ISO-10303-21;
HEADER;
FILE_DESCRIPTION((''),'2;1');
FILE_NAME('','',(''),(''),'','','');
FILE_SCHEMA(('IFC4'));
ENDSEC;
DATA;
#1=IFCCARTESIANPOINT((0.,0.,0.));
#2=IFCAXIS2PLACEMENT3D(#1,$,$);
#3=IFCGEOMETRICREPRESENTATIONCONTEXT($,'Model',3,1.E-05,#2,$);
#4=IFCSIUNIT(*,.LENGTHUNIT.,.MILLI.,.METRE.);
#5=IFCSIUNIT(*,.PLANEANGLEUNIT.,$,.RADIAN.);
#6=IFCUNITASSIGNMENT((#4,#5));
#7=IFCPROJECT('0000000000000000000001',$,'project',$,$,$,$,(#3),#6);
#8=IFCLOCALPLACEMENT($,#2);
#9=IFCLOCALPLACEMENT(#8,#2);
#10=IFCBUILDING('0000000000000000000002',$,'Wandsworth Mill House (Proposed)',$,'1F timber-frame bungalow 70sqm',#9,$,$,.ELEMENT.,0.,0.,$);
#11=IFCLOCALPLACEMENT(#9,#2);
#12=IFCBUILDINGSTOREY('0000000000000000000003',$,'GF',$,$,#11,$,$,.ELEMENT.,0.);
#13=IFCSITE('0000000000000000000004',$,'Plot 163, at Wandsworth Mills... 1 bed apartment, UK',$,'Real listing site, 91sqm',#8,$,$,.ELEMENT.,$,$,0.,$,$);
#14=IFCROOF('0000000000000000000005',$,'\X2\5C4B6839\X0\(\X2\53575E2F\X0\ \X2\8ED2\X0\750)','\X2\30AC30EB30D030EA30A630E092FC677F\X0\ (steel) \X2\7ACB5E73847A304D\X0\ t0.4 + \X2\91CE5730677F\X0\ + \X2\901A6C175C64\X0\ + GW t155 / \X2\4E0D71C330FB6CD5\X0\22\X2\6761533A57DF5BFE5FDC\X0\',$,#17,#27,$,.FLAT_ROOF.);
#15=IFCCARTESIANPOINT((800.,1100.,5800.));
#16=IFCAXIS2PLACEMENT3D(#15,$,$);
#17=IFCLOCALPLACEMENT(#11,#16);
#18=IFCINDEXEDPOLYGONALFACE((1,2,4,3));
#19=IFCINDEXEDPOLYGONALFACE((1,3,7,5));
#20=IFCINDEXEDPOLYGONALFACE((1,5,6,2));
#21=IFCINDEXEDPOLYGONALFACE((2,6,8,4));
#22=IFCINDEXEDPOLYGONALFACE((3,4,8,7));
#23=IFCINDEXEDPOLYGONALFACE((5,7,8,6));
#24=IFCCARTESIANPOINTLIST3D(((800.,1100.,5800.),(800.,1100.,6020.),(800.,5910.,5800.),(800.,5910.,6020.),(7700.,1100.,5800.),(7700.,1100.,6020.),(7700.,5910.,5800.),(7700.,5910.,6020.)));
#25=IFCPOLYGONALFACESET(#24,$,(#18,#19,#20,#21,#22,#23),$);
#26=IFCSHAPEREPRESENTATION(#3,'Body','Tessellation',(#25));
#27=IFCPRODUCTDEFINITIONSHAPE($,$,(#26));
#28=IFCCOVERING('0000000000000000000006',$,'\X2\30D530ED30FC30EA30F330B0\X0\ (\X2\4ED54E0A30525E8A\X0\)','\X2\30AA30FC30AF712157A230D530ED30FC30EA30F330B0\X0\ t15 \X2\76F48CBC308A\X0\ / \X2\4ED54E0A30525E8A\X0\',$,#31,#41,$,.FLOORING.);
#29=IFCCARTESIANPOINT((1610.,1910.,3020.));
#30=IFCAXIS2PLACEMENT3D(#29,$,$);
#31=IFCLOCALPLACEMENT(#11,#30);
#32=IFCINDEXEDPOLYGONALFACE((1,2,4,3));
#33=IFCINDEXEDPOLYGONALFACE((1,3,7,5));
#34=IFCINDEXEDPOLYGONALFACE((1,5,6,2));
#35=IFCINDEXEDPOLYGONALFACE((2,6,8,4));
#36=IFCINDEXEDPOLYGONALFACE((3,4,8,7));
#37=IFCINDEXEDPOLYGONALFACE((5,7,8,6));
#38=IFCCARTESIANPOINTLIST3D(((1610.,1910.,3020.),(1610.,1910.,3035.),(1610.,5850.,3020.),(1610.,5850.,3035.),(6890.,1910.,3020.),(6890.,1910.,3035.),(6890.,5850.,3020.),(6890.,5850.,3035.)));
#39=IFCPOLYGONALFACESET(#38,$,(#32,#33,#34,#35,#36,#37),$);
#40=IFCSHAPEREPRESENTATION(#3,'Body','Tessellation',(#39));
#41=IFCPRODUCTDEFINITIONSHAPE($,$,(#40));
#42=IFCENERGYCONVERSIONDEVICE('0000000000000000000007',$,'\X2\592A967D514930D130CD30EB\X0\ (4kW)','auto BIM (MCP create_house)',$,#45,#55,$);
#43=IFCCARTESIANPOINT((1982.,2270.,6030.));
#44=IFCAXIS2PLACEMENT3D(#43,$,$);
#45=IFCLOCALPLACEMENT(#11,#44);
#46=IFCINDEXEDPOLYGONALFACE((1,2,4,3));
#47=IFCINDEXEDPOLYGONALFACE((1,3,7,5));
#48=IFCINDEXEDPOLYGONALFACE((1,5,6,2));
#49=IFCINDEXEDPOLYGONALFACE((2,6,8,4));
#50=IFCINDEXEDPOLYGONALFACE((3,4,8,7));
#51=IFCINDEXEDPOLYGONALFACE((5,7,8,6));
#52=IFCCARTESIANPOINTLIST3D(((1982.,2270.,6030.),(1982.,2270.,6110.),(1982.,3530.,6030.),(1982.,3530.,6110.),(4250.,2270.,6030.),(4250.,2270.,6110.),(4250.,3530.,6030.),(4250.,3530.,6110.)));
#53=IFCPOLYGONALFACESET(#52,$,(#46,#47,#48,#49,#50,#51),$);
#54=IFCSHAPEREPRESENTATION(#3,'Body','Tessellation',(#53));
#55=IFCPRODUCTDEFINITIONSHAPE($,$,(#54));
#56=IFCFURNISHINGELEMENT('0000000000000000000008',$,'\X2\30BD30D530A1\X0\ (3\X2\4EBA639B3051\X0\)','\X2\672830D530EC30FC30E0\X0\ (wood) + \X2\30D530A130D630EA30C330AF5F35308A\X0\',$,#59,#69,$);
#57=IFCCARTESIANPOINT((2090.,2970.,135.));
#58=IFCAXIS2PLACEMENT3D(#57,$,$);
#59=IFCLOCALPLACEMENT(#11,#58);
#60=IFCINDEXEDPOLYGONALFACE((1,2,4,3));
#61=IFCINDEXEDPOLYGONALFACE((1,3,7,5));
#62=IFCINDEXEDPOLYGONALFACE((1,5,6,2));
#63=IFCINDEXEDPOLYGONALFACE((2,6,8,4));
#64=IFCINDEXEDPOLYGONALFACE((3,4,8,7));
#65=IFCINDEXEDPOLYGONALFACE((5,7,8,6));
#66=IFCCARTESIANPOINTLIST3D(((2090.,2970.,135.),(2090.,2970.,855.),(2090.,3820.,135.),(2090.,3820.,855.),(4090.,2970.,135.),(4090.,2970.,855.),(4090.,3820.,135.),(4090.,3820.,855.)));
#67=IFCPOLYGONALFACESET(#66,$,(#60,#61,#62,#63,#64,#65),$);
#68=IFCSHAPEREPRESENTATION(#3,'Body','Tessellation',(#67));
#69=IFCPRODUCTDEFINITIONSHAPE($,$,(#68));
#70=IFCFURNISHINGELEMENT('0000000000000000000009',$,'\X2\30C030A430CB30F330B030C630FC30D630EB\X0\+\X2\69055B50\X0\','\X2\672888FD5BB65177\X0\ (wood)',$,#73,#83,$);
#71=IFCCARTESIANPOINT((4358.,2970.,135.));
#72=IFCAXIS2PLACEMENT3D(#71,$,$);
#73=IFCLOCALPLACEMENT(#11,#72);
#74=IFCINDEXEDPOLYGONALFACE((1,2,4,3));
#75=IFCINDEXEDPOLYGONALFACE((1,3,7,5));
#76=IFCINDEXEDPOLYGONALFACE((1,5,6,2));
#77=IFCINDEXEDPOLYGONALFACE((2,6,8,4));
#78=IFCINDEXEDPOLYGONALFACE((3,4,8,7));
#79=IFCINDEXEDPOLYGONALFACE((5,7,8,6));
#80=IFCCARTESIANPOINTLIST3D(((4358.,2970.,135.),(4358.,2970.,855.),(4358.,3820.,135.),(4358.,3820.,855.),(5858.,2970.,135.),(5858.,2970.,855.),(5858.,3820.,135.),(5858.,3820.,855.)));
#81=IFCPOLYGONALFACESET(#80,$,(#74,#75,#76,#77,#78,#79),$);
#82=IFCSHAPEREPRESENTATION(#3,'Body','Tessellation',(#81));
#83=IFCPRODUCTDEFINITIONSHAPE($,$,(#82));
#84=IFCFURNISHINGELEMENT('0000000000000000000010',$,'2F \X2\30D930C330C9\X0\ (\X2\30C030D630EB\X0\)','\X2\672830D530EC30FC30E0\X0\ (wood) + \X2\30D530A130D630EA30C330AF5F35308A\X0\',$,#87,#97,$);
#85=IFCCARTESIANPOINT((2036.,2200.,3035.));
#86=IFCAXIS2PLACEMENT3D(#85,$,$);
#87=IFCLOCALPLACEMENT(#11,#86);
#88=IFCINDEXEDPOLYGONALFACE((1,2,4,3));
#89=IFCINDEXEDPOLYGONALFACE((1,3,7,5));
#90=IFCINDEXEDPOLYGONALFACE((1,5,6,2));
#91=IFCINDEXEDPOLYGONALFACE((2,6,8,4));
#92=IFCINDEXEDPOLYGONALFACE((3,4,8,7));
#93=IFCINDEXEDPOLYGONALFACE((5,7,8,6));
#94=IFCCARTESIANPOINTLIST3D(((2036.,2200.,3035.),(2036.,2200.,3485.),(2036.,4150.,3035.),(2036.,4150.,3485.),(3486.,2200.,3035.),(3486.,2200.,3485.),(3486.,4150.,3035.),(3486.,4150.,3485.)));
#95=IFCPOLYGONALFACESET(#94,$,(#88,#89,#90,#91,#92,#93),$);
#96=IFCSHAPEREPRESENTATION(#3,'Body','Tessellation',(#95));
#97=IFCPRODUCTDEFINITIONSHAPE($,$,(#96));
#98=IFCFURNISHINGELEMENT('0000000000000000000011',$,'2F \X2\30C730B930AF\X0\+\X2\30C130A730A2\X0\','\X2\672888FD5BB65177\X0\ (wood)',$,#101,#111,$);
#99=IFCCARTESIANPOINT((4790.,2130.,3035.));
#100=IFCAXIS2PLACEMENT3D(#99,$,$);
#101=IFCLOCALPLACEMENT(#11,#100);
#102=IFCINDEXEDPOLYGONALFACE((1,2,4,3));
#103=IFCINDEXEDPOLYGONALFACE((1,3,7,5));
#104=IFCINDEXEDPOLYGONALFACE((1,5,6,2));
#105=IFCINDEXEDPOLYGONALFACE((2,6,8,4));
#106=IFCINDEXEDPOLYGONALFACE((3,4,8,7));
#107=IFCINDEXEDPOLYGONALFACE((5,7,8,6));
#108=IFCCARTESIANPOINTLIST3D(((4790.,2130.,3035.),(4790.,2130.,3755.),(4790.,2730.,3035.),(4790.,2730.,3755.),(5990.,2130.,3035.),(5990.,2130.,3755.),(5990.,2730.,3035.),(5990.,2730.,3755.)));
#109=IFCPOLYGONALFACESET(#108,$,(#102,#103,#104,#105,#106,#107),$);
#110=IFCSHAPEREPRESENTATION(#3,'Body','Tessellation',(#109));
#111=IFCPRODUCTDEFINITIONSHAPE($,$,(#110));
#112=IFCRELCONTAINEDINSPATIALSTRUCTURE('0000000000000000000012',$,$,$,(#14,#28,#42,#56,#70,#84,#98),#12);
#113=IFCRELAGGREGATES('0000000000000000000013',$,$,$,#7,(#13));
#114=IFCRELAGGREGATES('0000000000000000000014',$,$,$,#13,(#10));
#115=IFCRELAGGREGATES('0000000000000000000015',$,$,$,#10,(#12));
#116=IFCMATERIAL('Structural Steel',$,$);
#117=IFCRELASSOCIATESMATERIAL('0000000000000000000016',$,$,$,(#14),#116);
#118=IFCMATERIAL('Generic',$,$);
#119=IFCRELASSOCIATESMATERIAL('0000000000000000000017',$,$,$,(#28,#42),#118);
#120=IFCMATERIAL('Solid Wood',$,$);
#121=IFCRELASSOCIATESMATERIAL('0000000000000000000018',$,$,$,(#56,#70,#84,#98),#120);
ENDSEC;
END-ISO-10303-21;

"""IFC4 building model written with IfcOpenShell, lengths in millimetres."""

from ifc_helpers import new_model, si_unit, frame, frame_2d, origin, place, context, project, spatial, rectangle, extrude, material, element, save


model = new_model("IFC4")

# Units and contexts
model_context = context("Model", 3, precision=1e-05, world=origin())
ifc_project = project(units=[si_unit("LENGTHUNIT", "METRE", prefix="MILLI"), si_unit("PLANEANGLEUNIT", "RADIAN")], contexts=[model_context])

# Site, building, storey
site_placement = place(None, origin())
site = spatial("IfcSite", under=ifc_project, at=site_placement, Name="Plot 163, at Wandsworth Mills... 1 bed apartment, UK", ObjectType="Real listing site, 91sqm", CompositionType="ELEMENT", RefElevation=0.0)
building_placement = place(site_placement, origin())
building = spatial("IfcBuilding", under=site, at=building_placement, Name="Wandsworth Mill House (Proposed)", ObjectType="1F timber-frame bungalow 70sqm", CompositionType="ELEMENT", ElevationOfRefHeight=0.0, ElevationOfTerrain=0.0)
storey_placement = place(building_placement, origin())
storey = spatial("IfcBuildingStorey", under=building, at=storey_placement, Name="GF", CompositionType="ELEMENT", Elevation=0.0)

# Shared definitions
ifc_material_1 = material(Name="Solid Wood")

# Shared definitions
ifc_material_2 = material(Name="Generic")

# Roof
ifc_material_3 = material(Name="Structural Steel")
for number, where, name in (
    (1, (800.0, 1100.0, 5800.0), "屋根(南帯 軒750)"),
):
    element("IfcRoof", number, at=place(storey_placement, frame(where)), inside=storey, material=ifc_material_3, Name=name, Description="ガルバリウム鋼板 (steel) 立平葺き t0.4 + 野地板 + 通気層 + GW t155 / 不燃・法22条区域対応", PredefinedType="FLAT_ROOF", context=model_context, shape_type="SweptSolid", body=[
        extrude(rectangle(XDim=6900.0, YDim=4810.0, at=frame_2d((3450.0, 2405.0))), frame((800.0, 1100.0, 5800.0)), (0.0, 0.0, 1.0), 220.0),
    ])

# Covering
covering_placement = place(storey_placement, frame((1610.0, 1910.0, 3020.0)))
element("IfcCovering", 2, at=covering_placement, inside=storey, material=ifc_material_2, Name="フローリング (仕上げ床)", Description="オーク無垢フローリング t15 直貼り / 仕上げ床", PredefinedType="FLOORING", context=model_context, shape_type="SweptSolid", body=[
    extrude(rectangle(XDim=5280.0, YDim=3940.0, at=frame_2d((2640.0, 1970.0))), frame((1610.0, 1910.0, 3020.0)), (0.0, 0.0, 1.0), 15.0),
])

# Energy conversion device
energy_conversion_device_placement = place(storey_placement, frame((1982.0, 2270.0, 6030.0)))
element("IfcEnergyConversionDevice", 3, at=energy_conversion_device_placement, inside=storey, material=ifc_material_2, Name="太陽光パネル (4kW)", Description="auto BIM (MCP create_house)", context=model_context, shape_type="SweptSolid", body=[
    extrude(rectangle(XDim=2268.0, YDim=1260.0, at=frame_2d((1134.0, 630.0))), frame((1982.0, 2270.0, 6030.0)), (0.0, 0.0, 1.0), 80.0),
])

# Furnishing elements
furnishing_1_placement = place(storey_placement, frame((2090.0, 2970.0, 135.0)))
element("IfcFurnishingElement", 4, at=furnishing_1_placement, inside=storey, material=ifc_material_1, Name="ソファ (3人掛け)", Description="木フレーム (wood) + ファブリック張り", context=model_context, shape_type="SweptSolid", body=[
    extrude(rectangle(XDim=2000.0, YDim=850.0, at=frame_2d((1000.0, 425.0))), frame((2090.0, 2970.0, 135.0)), (0.0, 0.0, 1.0), 720.0),
])
furnishing_2_placement = place(storey_placement, frame((4358.0, 2970.0, 135.0)))
element("IfcFurnishingElement", 5, at=furnishing_2_placement, inside=storey, material=ifc_material_1, Name="ダイニングテーブル+椅子", Description="木製家具 (wood)", context=model_context, shape_type="SweptSolid", body=[
    extrude(rectangle(XDim=1500.0, YDim=850.0, at=frame_2d((750.0, 425.0))), frame((4358.0, 2970.0, 135.0)), (0.0, 0.0, 1.0), 720.0),
])
furnishing_3_placement = place(storey_placement, frame((2036.0, 2200.0, 3035.0)))
element("IfcFurnishingElement", 6, at=furnishing_3_placement, inside=storey, material=ifc_material_1, Name="2F ベッド (ダブル)", Description="木フレーム (wood) + ファブリック張り", context=model_context, shape_type="SweptSolid", body=[
    extrude(rectangle(XDim=1450.0, YDim=1950.0, at=frame_2d((725.0, 975.0))), frame((2036.0, 2200.0, 3035.0)), (0.0, 0.0, 1.0), 450.0),
])
furnishing_4_placement = place(storey_placement, frame((4790.0, 2130.0, 3035.0)))
element("IfcFurnishingElement", 7, at=furnishing_4_placement, inside=storey, material=ifc_material_1, Name="2F デスク+チェア", Description="木製家具 (wood)", context=model_context, shape_type="SweptSolid", body=[
    extrude(rectangle(XDim=1200.0, YDim=600.0, at=frame_2d((600.0, 300.0))), frame((4790.0, 2130.0, 3035.0)), (0.0, 0.0, 1.0), 720.0),
])

save(model, "model.ifc")
